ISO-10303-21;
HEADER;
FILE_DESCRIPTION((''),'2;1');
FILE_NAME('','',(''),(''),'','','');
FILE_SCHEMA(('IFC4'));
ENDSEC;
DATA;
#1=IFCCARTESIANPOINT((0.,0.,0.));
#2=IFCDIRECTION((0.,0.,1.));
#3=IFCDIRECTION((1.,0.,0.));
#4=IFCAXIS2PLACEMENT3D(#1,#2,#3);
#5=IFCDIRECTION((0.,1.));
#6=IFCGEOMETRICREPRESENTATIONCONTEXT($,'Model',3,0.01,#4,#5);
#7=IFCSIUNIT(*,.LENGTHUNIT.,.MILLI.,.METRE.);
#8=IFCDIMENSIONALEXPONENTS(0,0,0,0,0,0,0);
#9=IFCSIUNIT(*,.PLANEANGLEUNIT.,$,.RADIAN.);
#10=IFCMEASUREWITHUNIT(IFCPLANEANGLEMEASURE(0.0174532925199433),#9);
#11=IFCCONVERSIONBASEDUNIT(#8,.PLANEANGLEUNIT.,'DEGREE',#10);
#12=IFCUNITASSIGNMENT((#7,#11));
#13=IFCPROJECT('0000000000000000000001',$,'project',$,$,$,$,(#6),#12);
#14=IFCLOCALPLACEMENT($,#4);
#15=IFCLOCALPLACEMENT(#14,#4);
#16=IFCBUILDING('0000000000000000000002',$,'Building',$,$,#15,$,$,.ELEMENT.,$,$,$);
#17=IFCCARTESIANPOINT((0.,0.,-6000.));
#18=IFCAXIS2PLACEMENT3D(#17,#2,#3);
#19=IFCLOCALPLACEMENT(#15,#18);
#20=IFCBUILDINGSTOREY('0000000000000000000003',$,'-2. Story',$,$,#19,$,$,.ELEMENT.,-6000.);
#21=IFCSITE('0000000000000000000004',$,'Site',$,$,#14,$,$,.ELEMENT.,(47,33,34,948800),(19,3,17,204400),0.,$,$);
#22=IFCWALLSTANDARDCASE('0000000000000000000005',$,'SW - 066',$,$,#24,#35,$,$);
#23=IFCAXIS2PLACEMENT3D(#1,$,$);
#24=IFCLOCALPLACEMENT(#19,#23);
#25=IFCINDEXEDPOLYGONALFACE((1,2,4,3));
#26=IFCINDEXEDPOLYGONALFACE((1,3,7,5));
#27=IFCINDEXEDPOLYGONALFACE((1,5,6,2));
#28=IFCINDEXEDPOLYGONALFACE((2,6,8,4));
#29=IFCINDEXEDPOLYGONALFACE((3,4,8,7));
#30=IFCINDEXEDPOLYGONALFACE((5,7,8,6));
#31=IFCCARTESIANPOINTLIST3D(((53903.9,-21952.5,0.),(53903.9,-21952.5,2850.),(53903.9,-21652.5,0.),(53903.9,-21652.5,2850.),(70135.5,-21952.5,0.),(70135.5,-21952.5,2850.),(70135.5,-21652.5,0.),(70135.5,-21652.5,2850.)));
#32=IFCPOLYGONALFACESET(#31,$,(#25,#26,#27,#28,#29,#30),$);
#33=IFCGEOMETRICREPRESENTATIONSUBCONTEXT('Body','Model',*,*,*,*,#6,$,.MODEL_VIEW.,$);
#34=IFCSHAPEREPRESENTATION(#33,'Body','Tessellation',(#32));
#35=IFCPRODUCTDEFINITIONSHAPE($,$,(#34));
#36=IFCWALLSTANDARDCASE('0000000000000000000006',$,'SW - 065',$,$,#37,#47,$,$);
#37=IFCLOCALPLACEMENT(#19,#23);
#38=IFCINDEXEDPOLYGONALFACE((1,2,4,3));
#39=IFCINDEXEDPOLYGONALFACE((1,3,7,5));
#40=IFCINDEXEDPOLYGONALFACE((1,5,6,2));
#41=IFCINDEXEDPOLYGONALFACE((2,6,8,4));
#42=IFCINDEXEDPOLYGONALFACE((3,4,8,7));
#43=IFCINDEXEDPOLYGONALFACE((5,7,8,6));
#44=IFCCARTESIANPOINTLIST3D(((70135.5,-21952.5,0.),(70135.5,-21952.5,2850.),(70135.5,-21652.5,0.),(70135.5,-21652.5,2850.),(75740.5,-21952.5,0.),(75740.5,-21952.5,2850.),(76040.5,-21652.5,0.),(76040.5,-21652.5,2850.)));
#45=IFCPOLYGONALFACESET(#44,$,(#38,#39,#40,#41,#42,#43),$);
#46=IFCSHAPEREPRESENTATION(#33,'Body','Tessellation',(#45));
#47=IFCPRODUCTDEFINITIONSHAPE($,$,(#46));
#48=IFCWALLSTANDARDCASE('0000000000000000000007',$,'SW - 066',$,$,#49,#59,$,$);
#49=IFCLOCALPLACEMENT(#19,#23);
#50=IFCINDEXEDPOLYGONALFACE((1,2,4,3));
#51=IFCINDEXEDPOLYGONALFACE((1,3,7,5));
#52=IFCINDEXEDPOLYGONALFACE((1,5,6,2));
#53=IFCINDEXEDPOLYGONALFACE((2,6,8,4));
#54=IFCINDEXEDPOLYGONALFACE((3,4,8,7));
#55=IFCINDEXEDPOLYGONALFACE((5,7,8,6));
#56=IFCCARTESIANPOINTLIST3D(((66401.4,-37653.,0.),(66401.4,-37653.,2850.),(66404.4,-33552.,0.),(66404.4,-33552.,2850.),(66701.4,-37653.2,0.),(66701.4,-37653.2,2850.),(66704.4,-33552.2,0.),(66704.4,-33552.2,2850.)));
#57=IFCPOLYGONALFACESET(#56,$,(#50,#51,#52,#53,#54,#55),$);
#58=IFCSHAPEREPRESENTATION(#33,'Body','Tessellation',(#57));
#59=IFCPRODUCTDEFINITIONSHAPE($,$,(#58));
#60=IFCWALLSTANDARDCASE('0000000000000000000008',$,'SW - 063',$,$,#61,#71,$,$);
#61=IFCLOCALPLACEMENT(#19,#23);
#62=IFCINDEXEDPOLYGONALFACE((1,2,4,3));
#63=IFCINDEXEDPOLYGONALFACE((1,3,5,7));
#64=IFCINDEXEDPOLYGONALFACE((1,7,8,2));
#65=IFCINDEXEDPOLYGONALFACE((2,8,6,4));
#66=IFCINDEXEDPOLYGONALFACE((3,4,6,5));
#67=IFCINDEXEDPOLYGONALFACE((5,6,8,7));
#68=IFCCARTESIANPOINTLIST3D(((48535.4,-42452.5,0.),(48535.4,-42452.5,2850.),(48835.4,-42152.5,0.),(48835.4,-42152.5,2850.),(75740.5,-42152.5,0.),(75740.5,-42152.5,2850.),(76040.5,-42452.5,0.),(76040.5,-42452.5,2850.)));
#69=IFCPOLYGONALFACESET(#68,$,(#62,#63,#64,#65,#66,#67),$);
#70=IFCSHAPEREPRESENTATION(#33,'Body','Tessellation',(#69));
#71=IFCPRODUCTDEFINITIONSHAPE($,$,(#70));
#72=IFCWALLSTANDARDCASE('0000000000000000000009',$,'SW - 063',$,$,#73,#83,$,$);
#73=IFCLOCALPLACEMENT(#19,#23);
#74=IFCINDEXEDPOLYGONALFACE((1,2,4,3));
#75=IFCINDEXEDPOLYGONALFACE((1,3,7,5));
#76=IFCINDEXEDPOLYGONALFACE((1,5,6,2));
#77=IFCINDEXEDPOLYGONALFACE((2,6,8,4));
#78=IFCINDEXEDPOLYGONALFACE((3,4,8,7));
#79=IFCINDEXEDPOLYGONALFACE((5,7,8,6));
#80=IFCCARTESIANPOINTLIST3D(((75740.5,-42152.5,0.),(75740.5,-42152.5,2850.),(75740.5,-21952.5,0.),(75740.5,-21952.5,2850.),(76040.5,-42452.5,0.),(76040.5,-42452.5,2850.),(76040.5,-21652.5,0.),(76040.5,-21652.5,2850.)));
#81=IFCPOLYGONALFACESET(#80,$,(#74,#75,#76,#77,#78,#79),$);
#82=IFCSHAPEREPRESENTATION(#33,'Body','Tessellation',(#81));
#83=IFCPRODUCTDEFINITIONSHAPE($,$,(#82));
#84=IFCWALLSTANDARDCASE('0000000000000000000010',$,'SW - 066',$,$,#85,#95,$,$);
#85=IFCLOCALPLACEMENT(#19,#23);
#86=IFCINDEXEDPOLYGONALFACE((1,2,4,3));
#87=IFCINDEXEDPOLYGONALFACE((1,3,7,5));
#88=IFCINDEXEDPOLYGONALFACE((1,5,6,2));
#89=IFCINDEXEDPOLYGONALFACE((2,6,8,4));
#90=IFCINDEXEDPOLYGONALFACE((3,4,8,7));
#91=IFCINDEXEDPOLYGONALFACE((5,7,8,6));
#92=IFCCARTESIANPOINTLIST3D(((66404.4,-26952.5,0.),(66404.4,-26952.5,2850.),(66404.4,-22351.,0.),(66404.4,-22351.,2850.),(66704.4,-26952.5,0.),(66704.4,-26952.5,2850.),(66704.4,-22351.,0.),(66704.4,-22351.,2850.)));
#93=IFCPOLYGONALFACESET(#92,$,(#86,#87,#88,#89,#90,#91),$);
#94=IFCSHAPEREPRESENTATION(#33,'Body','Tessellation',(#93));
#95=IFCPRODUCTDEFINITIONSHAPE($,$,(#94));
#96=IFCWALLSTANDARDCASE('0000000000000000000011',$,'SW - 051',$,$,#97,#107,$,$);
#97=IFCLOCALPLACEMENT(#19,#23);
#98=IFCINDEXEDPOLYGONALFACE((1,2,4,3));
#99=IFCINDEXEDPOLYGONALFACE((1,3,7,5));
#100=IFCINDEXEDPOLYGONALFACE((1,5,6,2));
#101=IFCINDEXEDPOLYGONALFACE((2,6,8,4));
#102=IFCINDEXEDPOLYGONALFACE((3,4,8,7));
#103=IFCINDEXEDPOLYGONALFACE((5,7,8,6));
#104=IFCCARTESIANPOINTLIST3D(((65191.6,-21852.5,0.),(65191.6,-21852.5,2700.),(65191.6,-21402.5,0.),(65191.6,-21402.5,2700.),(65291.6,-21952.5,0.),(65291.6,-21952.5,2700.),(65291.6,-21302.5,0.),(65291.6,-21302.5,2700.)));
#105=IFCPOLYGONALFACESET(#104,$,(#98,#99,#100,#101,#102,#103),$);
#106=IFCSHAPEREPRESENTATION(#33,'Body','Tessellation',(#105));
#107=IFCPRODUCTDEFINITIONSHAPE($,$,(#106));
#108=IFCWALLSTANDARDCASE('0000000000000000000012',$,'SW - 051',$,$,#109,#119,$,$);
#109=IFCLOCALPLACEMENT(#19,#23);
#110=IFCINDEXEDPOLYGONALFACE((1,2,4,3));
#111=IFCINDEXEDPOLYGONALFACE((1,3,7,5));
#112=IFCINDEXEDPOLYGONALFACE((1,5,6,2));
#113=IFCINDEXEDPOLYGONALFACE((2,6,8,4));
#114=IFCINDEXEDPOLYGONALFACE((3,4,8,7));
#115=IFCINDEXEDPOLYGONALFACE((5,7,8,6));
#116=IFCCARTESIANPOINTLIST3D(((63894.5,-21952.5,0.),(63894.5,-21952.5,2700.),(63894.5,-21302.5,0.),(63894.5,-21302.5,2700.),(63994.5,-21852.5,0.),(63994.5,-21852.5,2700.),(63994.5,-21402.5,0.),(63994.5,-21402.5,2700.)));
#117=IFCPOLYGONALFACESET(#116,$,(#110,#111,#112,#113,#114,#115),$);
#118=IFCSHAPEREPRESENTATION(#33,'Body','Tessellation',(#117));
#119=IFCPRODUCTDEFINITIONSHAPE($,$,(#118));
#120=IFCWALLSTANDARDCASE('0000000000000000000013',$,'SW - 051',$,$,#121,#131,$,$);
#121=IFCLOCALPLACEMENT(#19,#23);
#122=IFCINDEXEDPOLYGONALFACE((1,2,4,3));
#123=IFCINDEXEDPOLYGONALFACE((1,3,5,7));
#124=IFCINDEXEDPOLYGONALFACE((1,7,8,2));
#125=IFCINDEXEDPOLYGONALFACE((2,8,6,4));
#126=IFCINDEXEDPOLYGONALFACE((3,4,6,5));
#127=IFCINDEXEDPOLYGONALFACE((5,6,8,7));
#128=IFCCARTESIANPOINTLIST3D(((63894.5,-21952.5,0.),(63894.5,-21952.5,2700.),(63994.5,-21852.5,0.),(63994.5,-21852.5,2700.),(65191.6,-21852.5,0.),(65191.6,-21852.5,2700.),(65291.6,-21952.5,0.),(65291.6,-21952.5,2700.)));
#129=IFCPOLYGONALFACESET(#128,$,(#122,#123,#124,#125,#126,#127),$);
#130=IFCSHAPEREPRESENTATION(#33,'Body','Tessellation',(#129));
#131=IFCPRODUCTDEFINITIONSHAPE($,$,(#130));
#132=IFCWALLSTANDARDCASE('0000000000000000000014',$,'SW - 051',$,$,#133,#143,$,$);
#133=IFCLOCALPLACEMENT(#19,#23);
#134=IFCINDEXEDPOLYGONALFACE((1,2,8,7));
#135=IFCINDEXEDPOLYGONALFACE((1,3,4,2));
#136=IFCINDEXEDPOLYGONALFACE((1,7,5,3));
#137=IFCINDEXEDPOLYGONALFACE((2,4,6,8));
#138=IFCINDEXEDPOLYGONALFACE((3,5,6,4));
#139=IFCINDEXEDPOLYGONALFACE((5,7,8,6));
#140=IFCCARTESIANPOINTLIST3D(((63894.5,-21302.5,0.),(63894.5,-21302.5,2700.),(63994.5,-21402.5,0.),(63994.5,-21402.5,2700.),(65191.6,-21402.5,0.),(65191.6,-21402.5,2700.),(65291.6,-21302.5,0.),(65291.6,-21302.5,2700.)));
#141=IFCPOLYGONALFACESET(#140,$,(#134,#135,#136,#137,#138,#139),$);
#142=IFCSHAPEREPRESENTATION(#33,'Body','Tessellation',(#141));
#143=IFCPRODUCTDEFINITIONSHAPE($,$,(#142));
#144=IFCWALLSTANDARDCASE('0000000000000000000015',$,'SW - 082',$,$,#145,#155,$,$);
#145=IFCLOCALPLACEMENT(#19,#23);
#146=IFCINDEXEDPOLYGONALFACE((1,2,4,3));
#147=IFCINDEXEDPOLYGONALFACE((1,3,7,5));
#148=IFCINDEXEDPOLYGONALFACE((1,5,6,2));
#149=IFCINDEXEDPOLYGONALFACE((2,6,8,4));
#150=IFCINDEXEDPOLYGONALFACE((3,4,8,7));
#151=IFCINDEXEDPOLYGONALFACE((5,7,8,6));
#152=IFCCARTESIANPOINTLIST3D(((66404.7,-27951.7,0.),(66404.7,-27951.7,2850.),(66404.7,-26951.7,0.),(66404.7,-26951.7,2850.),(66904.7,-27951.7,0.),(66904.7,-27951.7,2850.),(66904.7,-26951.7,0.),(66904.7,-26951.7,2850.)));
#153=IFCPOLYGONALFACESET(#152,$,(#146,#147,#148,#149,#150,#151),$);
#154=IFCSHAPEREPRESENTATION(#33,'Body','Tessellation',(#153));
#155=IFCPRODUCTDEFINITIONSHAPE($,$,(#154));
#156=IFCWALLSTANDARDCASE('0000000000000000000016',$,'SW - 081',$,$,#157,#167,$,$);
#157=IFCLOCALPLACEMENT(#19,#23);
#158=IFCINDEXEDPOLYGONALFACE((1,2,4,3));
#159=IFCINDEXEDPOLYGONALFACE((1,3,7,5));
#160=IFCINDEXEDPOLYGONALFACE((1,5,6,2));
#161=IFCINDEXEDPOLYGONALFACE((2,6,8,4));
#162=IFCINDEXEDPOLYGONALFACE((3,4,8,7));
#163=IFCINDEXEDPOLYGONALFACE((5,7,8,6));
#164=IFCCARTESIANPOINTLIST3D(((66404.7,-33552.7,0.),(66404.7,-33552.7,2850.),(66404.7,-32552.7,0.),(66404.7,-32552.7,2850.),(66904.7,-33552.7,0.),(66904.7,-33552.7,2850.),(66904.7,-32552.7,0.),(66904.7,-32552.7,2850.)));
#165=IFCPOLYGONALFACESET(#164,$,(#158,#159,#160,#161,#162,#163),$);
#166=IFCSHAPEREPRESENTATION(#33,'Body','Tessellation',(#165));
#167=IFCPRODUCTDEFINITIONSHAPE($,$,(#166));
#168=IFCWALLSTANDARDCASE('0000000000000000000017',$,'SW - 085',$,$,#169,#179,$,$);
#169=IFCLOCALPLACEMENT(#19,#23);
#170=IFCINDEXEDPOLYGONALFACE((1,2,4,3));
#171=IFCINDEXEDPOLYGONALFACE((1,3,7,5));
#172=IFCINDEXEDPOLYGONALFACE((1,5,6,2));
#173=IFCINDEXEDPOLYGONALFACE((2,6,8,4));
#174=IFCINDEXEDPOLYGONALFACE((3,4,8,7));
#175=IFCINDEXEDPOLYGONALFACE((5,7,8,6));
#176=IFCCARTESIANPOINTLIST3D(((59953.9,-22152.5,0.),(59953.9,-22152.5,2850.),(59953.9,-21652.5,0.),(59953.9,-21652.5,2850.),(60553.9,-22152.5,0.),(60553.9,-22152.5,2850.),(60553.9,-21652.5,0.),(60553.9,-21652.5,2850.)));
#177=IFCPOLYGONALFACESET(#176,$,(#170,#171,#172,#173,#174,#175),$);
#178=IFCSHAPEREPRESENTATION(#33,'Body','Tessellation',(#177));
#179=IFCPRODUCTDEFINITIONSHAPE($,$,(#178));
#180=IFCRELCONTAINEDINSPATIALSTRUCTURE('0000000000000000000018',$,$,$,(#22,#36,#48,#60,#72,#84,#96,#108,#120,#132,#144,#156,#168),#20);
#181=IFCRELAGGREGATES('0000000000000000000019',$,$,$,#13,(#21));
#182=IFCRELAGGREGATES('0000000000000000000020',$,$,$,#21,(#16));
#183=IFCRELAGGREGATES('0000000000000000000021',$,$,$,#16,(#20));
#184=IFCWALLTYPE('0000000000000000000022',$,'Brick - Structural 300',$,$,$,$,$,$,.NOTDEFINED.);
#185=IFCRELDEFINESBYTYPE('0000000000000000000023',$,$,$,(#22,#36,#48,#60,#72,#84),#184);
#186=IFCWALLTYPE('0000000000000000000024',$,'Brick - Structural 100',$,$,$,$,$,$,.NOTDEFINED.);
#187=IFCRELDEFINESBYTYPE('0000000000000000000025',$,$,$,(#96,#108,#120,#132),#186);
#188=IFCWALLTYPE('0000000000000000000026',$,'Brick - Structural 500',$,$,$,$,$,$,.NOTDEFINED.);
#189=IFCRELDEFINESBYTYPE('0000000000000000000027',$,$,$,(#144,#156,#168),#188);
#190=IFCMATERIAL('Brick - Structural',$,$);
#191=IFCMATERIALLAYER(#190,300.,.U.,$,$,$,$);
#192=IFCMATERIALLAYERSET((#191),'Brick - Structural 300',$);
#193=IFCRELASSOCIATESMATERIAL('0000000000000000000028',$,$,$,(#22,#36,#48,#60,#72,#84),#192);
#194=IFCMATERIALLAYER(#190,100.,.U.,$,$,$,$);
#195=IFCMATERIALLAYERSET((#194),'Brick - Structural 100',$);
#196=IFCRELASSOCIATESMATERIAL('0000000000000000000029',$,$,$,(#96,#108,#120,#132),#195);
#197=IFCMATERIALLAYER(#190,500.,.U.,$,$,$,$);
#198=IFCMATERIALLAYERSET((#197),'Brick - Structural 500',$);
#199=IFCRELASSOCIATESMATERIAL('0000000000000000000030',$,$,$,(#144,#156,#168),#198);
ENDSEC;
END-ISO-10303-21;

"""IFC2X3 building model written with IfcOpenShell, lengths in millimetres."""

from ifc_helpers import new_model, entity, si_unit, converted_unit, direction, frame, origin_with_axes, place, context, subcontext, project, spatial, polyline, outline, extrude, material, layer, layer_set, layer_usage, type_object, element, save


model = new_model("IFC2X3")

# Units and contexts
model_context = context("Model", 3, precision=0.01, world=origin_with_axes(), true_north=direction((0.0, 1.0)))
body_context = subcontext(model_context, "Body", "Model", "MODEL_VIEW")
ifc_project = project(units=[si_unit("LENGTHUNIT", "METRE", prefix="MILLI"), converted_unit("PLANEANGLEUNIT", "DEGREE", entity("IfcPlaneAngleMeasure", 0.0174532925199433), si_unit("PLANEANGLEUNIT", "RADIAN"), dimensions=[0, 0, 0, 0, 0, 0, 0])], contexts=[model_context])

# Site, building, storey
site_placement = place(None, origin_with_axes())
site = spatial("IfcSite", under=ifc_project, at=site_placement, Name="Site", CompositionType="ELEMENT", RefLatitude=(47, 33, 34, 948800), RefLongitude=(19, 3, 17, 204400), RefElevation=0.0)
building_placement = place(site_placement, origin_with_axes())
building = spatial("IfcBuilding", under=site, at=building_placement, Name="Building", CompositionType="ELEMENT")
storey_placement = place(building_placement, frame((0.0, 0.0, -6000.0), z_axis=(0.0, 0.0, 1.0), x_axis=(1.0, 0.0, 0.0)))
storey = spatial("IfcBuildingStorey", under=building, at=storey_placement, Name="-2. Story", CompositionType="ELEMENT", Elevation=-6000.0)

# Walls
ifc_material_1 = material(Name="Brick - Structural")
ifc_layer_1 = layer(ifc_material_1, 300.0, ventilated="UNKNOWN")
ifc_layer_set_1 = layer_set([ifc_layer_1], Name="Brick - Structural 300")
ifc_layer_usage_1 = layer_usage(ifc_layer_set_1, "AXIS2", "POSITIVE", 0.0)
wall_type_1 = type_object("IfcWallType", Name="Brick - Structural 300", PredefinedType="NOTDEFINED")
wall_1_placement = place(storey_placement, frame((70135.5, -21652.5, 0.0), z_axis=(0.0, 0.0, 1.0), x_axis=(-1.0, 0.0, 0.0)))
element("IfcWallStandardCase", 1, at=wall_1_placement, inside=storey, type_object=wall_type_1, material=ifc_layer_usage_1, Name="SW - 066", context=body_context, shape_type="SweptSolid", body=[
    extrude(outline(polyline([(0.0, 0.0), (16231.6, 0.0), (16231.6, 300.0), (0.0, 300.0), (0.0, 0.0)])), origin_with_axes(), (0.0, 0.0, 1.0), 2850.0),
])
ifc_layer_usage_2 = layer_usage(ifc_layer_set_1, "AXIS2", "POSITIVE", 0.0)
wall_2_placement = place(storey_placement, frame((76040.5, -21652.5, 0.0), z_axis=(0.0, 0.0, 1.0), x_axis=(-1.0, 0.0, 0.0)))
element("IfcWallStandardCase", 2, at=wall_2_placement, inside=storey, type_object=wall_type_1, material=ifc_layer_usage_2, Name="SW - 065", context=body_context, shape_type="SweptSolid", body=[
    extrude(outline(polyline([(0.0, 0.0), (5905.0, 0.0), (5905.0, 300.0), (300.0, 300.0), (0.0, 0.0)])), origin_with_axes(), (0.0, 0.0, 1.0), 2850.0),
])
ifc_layer_usage_3 = layer_usage(ifc_layer_set_1, "AXIS2", "POSITIVE", 0.0)
wall_3_placement = place(storey_placement, frame((66404.4, -33552.0, 0.0), z_axis=(0.0, 0.0, 1.0), x_axis=(-0.000749, -1.0, 0.0)))
element("IfcWallStandardCase", 3, at=wall_3_placement, inside=storey, type_object=wall_type_1, material=ifc_layer_usage_3, Name="SW - 066", context=body_context, shape_type="SweptSolid", body=[
    extrude(outline(polyline([(0.0, 0.0), (4101.0, 0.0), (4101.0, 300.0), (0.0, 300.0), (0.0, 0.0)])), origin_with_axes(), (0.0, 0.0, 1.0), 2850.0),
])
ifc_layer_usage_4 = layer_usage(ifc_layer_set_1, "AXIS2", "POSITIVE", 0.0)
wall_4_placement = place(storey_placement, frame((76040.5, -42152.5, 0.0), z_axis=(0.0, 0.0, 1.0), x_axis=(-1.0, 0.0, 0.0)))
element("IfcWallStandardCase", 4, at=wall_4_placement, inside=storey, type_object=wall_type_1, material=ifc_layer_usage_4, Name="SW - 063", context=body_context, shape_type="SweptSolid", body=[
    extrude(outline(polyline([(300.0, 0.0), (27205.0, 0.0), (27505.0, 300.0), (0.0, 300.0), (300.0, 0.0)])), origin_with_axes(), (0.0, 0.0, 1.0), 2850.0),
])
ifc_layer_usage_5 = layer_usage(ifc_layer_set_1, "AXIS2", "POSITIVE", 0.0)
wall_5_placement = place(storey_placement, frame((76040.5, -42152.5, 0.0), z_axis=(0.0, 0.0, 1.0), x_axis=(0.0, 1.0, 0.0)))
element("IfcWallStandardCase", 5, at=wall_5_placement, inside=storey, type_object=wall_type_1, material=ifc_layer_usage_5, Name="SW - 063", context=body_context, shape_type="SweptSolid", body=[
    extrude(outline(polyline([(-300.0, 0.0), (20500.0, 0.0), (20200.0, 300.0), (0.0, 300.0), (-300.0, 0.0)])), origin_with_axes(), (0.0, 0.0, 1.0), 2850.0),
])
ifc_layer_usage_6 = layer_usage(ifc_layer_set_1, "AXIS2", "POSITIVE", 0.0)
wall_6_placement = place(storey_placement, frame((66404.4, -22351.0, 0.0), z_axis=(0.0, 0.0, 1.0), x_axis=(0.0, -1.0, 0.0)))
element("IfcWallStandardCase", 6, at=wall_6_placement, inside=storey, type_object=wall_type_1, material=ifc_layer_usage_6, Name="SW - 066", context=body_context, shape_type="SweptSolid", body=[
    extrude(outline(polyline([(0.0, 0.0), (4601.5, 0.0), (4601.5, 300.0), (0.0, 300.0), (0.0, 0.0)])), origin_with_axes(), (0.0, 0.0, 1.0), 2850.0),
])
ifc_layer_2 = layer(ifc_material_1, 100.0, ventilated="UNKNOWN")
ifc_layer_set_2 = layer_set([ifc_layer_2], Name="Brick - Structural 100")
ifc_layer_usage_7 = layer_usage(ifc_layer_set_2, "AXIS2", "NEGATIVE", 0.0)
wall_type_2 = type_object("IfcWallType", Name="Brick - Structural 100", PredefinedType="NOTDEFINED")
wall_7_placement = place(storey_placement, frame((65191.6, -21952.5, 0.0), z_axis=(0.0, 0.0, 1.0), x_axis=(0.0, 1.0, 0.0)))
element("IfcWallStandardCase", 7, at=wall_7_placement, inside=storey, type_object=wall_type_2, material=ifc_layer_usage_7, Name="SW - 051", context=body_context, shape_type="SweptSolid", body=[
    extrude(outline(polyline([(0.0, -100.0), (650.0, -100.0), (550.0, 0.0), (100.0, 0.0), (0.0, -100.0)])), origin_with_axes(), (0.0, 0.0, 1.0), 2700.0),
])
ifc_layer_usage_8 = layer_usage(ifc_layer_set_2, "AXIS2", "NEGATIVE", 0.0)
wall_8_placement = place(storey_placement, frame((63894.5, -21952.5, 0.0), z_axis=(0.0, 0.0, 1.0), x_axis=(0.0, 1.0, 0.0)))
element("IfcWallStandardCase", 8, at=wall_8_placement, inside=storey, type_object=wall_type_2, material=ifc_layer_usage_8, Name="SW - 051", context=body_context, shape_type="SweptSolid", body=[
    extrude(outline(polyline([(100.0, -100.0), (550.0, -100.0), (650.0, 0.0), (0.0, 0.0), (100.0, -100.0)])), origin_with_axes(), (0.0, 0.0, 1.0), 2700.0),
])
ifc_layer_usage_9 = layer_usage(ifc_layer_set_2, "AXIS2", "NEGATIVE", 0.0)
wall_9_placement = place(storey_placement, frame((65191.6, -21952.5, 0.0), z_axis=(0.0, 0.0, 1.0), x_axis=(-1.0, 0.0, 0.0)))
element("IfcWallStandardCase", 9, at=wall_9_placement, inside=storey, type_object=wall_type_2, material=ifc_layer_usage_9, Name="SW - 051", context=body_context, shape_type="SweptSolid", body=[
    extrude(outline(polyline([(0.0, -100.0), (1197.1, -100.0), (1297.1, 0.0), (-100.0, 0.0), (0.0, -100.0)])), origin_with_axes(), (0.0, 0.0, 1.0), 2700.0),
])
ifc_layer_usage_10 = layer_usage(ifc_layer_set_2, "AXIS2", "NEGATIVE", 0.0)
wall_10_placement = place(storey_placement, frame((65191.6, -21402.5, 0.0), z_axis=(0.0, 0.0, 1.0), x_axis=(-1.0, 0.0, 0.0)))
element("IfcWallStandardCase", 10, at=wall_10_placement, inside=storey, type_object=wall_type_2, material=ifc_layer_usage_10, Name="SW - 051", context=body_context, shape_type="SweptSolid", body=[
    extrude(outline(polyline([(-100.0, -100.0), (1297.1, -100.0), (1197.1, 0.0), (0.0, 0.0), (-100.0, -100.0)])), origin_with_axes(), (0.0, 0.0, 1.0), 2700.0),
])
ifc_layer_3 = layer(ifc_material_1, 500.0, ventilated="UNKNOWN")
ifc_layer_set_3 = layer_set([ifc_layer_3], Name="Brick - Structural 500")
ifc_layer_usage_11 = layer_usage(ifc_layer_set_3, "AXIS2", "POSITIVE", 0.0)
wall_type_3 = type_object("IfcWallType", Name="Brick - Structural 500", PredefinedType="NOTDEFINED")
wall_11_placement = place(storey_placement, frame((66904.7, -27951.7, 0.0), z_axis=(0.0, 0.0, 1.0), x_axis=(0.0, 1.0, 0.0)))
element("IfcWallStandardCase", 11, at=wall_11_placement, inside=storey, type_object=wall_type_3, material=ifc_layer_usage_11, Name="SW - 082", context=body_context, shape_type="SweptSolid", body=[
    extrude(outline(polyline([(0.0, 0.0), (1000.0, 0.0), (1000.0, 500.0), (0.0, 500.0), (0.0, 0.0)])), origin_with_axes(), (0.0, 0.0, 1.0), 2850.0),
])
ifc_layer_usage_12 = layer_usage(ifc_layer_set_3, "AXIS2", "POSITIVE", 0.0)
wall_12_placement = place(storey_placement, frame((66904.7, -33552.7, 0.0), z_axis=(0.0, 0.0, 1.0), x_axis=(0.0, 1.0, 0.0)))
element("IfcWallStandardCase", 12, at=wall_12_placement, inside=storey, type_object=wall_type_3, material=ifc_layer_usage_12, Name="SW - 081", context=body_context, shape_type="SweptSolid", body=[
    extrude(outline(polyline([(0.0, 0.0), (1000.0, 0.0), (1000.0, 500.0), (0.0, 500.0), (0.0, 0.0)])), origin_with_axes(), (0.0, 0.0, 1.0), 2850.0),
])
ifc_layer_usage_13 = layer_usage(ifc_layer_set_3, "AXIS2", "POSITIVE", 0.0)
wall_13_placement = place(storey_placement, frame((60553.9, -21652.5, 0.0), z_axis=(0.0, 0.0, 1.0), x_axis=(-1.0, 0.0, 0.0)))
element("IfcWallStandardCase", 13, at=wall_13_placement, inside=storey, type_object=wall_type_3, material=ifc_layer_usage_13, Name="SW - 085", context=body_context, shape_type="SweptSolid", body=[
    extrude(outline(polyline([(0.0, 0.0), (600.0, 0.0), (600.0, 500.0), (0.0, 500.0), (0.0, 0.0)])), origin_with_axes(), (0.0, 0.0, 1.0), 2850.0),
])

save(model, "model.ifc")
